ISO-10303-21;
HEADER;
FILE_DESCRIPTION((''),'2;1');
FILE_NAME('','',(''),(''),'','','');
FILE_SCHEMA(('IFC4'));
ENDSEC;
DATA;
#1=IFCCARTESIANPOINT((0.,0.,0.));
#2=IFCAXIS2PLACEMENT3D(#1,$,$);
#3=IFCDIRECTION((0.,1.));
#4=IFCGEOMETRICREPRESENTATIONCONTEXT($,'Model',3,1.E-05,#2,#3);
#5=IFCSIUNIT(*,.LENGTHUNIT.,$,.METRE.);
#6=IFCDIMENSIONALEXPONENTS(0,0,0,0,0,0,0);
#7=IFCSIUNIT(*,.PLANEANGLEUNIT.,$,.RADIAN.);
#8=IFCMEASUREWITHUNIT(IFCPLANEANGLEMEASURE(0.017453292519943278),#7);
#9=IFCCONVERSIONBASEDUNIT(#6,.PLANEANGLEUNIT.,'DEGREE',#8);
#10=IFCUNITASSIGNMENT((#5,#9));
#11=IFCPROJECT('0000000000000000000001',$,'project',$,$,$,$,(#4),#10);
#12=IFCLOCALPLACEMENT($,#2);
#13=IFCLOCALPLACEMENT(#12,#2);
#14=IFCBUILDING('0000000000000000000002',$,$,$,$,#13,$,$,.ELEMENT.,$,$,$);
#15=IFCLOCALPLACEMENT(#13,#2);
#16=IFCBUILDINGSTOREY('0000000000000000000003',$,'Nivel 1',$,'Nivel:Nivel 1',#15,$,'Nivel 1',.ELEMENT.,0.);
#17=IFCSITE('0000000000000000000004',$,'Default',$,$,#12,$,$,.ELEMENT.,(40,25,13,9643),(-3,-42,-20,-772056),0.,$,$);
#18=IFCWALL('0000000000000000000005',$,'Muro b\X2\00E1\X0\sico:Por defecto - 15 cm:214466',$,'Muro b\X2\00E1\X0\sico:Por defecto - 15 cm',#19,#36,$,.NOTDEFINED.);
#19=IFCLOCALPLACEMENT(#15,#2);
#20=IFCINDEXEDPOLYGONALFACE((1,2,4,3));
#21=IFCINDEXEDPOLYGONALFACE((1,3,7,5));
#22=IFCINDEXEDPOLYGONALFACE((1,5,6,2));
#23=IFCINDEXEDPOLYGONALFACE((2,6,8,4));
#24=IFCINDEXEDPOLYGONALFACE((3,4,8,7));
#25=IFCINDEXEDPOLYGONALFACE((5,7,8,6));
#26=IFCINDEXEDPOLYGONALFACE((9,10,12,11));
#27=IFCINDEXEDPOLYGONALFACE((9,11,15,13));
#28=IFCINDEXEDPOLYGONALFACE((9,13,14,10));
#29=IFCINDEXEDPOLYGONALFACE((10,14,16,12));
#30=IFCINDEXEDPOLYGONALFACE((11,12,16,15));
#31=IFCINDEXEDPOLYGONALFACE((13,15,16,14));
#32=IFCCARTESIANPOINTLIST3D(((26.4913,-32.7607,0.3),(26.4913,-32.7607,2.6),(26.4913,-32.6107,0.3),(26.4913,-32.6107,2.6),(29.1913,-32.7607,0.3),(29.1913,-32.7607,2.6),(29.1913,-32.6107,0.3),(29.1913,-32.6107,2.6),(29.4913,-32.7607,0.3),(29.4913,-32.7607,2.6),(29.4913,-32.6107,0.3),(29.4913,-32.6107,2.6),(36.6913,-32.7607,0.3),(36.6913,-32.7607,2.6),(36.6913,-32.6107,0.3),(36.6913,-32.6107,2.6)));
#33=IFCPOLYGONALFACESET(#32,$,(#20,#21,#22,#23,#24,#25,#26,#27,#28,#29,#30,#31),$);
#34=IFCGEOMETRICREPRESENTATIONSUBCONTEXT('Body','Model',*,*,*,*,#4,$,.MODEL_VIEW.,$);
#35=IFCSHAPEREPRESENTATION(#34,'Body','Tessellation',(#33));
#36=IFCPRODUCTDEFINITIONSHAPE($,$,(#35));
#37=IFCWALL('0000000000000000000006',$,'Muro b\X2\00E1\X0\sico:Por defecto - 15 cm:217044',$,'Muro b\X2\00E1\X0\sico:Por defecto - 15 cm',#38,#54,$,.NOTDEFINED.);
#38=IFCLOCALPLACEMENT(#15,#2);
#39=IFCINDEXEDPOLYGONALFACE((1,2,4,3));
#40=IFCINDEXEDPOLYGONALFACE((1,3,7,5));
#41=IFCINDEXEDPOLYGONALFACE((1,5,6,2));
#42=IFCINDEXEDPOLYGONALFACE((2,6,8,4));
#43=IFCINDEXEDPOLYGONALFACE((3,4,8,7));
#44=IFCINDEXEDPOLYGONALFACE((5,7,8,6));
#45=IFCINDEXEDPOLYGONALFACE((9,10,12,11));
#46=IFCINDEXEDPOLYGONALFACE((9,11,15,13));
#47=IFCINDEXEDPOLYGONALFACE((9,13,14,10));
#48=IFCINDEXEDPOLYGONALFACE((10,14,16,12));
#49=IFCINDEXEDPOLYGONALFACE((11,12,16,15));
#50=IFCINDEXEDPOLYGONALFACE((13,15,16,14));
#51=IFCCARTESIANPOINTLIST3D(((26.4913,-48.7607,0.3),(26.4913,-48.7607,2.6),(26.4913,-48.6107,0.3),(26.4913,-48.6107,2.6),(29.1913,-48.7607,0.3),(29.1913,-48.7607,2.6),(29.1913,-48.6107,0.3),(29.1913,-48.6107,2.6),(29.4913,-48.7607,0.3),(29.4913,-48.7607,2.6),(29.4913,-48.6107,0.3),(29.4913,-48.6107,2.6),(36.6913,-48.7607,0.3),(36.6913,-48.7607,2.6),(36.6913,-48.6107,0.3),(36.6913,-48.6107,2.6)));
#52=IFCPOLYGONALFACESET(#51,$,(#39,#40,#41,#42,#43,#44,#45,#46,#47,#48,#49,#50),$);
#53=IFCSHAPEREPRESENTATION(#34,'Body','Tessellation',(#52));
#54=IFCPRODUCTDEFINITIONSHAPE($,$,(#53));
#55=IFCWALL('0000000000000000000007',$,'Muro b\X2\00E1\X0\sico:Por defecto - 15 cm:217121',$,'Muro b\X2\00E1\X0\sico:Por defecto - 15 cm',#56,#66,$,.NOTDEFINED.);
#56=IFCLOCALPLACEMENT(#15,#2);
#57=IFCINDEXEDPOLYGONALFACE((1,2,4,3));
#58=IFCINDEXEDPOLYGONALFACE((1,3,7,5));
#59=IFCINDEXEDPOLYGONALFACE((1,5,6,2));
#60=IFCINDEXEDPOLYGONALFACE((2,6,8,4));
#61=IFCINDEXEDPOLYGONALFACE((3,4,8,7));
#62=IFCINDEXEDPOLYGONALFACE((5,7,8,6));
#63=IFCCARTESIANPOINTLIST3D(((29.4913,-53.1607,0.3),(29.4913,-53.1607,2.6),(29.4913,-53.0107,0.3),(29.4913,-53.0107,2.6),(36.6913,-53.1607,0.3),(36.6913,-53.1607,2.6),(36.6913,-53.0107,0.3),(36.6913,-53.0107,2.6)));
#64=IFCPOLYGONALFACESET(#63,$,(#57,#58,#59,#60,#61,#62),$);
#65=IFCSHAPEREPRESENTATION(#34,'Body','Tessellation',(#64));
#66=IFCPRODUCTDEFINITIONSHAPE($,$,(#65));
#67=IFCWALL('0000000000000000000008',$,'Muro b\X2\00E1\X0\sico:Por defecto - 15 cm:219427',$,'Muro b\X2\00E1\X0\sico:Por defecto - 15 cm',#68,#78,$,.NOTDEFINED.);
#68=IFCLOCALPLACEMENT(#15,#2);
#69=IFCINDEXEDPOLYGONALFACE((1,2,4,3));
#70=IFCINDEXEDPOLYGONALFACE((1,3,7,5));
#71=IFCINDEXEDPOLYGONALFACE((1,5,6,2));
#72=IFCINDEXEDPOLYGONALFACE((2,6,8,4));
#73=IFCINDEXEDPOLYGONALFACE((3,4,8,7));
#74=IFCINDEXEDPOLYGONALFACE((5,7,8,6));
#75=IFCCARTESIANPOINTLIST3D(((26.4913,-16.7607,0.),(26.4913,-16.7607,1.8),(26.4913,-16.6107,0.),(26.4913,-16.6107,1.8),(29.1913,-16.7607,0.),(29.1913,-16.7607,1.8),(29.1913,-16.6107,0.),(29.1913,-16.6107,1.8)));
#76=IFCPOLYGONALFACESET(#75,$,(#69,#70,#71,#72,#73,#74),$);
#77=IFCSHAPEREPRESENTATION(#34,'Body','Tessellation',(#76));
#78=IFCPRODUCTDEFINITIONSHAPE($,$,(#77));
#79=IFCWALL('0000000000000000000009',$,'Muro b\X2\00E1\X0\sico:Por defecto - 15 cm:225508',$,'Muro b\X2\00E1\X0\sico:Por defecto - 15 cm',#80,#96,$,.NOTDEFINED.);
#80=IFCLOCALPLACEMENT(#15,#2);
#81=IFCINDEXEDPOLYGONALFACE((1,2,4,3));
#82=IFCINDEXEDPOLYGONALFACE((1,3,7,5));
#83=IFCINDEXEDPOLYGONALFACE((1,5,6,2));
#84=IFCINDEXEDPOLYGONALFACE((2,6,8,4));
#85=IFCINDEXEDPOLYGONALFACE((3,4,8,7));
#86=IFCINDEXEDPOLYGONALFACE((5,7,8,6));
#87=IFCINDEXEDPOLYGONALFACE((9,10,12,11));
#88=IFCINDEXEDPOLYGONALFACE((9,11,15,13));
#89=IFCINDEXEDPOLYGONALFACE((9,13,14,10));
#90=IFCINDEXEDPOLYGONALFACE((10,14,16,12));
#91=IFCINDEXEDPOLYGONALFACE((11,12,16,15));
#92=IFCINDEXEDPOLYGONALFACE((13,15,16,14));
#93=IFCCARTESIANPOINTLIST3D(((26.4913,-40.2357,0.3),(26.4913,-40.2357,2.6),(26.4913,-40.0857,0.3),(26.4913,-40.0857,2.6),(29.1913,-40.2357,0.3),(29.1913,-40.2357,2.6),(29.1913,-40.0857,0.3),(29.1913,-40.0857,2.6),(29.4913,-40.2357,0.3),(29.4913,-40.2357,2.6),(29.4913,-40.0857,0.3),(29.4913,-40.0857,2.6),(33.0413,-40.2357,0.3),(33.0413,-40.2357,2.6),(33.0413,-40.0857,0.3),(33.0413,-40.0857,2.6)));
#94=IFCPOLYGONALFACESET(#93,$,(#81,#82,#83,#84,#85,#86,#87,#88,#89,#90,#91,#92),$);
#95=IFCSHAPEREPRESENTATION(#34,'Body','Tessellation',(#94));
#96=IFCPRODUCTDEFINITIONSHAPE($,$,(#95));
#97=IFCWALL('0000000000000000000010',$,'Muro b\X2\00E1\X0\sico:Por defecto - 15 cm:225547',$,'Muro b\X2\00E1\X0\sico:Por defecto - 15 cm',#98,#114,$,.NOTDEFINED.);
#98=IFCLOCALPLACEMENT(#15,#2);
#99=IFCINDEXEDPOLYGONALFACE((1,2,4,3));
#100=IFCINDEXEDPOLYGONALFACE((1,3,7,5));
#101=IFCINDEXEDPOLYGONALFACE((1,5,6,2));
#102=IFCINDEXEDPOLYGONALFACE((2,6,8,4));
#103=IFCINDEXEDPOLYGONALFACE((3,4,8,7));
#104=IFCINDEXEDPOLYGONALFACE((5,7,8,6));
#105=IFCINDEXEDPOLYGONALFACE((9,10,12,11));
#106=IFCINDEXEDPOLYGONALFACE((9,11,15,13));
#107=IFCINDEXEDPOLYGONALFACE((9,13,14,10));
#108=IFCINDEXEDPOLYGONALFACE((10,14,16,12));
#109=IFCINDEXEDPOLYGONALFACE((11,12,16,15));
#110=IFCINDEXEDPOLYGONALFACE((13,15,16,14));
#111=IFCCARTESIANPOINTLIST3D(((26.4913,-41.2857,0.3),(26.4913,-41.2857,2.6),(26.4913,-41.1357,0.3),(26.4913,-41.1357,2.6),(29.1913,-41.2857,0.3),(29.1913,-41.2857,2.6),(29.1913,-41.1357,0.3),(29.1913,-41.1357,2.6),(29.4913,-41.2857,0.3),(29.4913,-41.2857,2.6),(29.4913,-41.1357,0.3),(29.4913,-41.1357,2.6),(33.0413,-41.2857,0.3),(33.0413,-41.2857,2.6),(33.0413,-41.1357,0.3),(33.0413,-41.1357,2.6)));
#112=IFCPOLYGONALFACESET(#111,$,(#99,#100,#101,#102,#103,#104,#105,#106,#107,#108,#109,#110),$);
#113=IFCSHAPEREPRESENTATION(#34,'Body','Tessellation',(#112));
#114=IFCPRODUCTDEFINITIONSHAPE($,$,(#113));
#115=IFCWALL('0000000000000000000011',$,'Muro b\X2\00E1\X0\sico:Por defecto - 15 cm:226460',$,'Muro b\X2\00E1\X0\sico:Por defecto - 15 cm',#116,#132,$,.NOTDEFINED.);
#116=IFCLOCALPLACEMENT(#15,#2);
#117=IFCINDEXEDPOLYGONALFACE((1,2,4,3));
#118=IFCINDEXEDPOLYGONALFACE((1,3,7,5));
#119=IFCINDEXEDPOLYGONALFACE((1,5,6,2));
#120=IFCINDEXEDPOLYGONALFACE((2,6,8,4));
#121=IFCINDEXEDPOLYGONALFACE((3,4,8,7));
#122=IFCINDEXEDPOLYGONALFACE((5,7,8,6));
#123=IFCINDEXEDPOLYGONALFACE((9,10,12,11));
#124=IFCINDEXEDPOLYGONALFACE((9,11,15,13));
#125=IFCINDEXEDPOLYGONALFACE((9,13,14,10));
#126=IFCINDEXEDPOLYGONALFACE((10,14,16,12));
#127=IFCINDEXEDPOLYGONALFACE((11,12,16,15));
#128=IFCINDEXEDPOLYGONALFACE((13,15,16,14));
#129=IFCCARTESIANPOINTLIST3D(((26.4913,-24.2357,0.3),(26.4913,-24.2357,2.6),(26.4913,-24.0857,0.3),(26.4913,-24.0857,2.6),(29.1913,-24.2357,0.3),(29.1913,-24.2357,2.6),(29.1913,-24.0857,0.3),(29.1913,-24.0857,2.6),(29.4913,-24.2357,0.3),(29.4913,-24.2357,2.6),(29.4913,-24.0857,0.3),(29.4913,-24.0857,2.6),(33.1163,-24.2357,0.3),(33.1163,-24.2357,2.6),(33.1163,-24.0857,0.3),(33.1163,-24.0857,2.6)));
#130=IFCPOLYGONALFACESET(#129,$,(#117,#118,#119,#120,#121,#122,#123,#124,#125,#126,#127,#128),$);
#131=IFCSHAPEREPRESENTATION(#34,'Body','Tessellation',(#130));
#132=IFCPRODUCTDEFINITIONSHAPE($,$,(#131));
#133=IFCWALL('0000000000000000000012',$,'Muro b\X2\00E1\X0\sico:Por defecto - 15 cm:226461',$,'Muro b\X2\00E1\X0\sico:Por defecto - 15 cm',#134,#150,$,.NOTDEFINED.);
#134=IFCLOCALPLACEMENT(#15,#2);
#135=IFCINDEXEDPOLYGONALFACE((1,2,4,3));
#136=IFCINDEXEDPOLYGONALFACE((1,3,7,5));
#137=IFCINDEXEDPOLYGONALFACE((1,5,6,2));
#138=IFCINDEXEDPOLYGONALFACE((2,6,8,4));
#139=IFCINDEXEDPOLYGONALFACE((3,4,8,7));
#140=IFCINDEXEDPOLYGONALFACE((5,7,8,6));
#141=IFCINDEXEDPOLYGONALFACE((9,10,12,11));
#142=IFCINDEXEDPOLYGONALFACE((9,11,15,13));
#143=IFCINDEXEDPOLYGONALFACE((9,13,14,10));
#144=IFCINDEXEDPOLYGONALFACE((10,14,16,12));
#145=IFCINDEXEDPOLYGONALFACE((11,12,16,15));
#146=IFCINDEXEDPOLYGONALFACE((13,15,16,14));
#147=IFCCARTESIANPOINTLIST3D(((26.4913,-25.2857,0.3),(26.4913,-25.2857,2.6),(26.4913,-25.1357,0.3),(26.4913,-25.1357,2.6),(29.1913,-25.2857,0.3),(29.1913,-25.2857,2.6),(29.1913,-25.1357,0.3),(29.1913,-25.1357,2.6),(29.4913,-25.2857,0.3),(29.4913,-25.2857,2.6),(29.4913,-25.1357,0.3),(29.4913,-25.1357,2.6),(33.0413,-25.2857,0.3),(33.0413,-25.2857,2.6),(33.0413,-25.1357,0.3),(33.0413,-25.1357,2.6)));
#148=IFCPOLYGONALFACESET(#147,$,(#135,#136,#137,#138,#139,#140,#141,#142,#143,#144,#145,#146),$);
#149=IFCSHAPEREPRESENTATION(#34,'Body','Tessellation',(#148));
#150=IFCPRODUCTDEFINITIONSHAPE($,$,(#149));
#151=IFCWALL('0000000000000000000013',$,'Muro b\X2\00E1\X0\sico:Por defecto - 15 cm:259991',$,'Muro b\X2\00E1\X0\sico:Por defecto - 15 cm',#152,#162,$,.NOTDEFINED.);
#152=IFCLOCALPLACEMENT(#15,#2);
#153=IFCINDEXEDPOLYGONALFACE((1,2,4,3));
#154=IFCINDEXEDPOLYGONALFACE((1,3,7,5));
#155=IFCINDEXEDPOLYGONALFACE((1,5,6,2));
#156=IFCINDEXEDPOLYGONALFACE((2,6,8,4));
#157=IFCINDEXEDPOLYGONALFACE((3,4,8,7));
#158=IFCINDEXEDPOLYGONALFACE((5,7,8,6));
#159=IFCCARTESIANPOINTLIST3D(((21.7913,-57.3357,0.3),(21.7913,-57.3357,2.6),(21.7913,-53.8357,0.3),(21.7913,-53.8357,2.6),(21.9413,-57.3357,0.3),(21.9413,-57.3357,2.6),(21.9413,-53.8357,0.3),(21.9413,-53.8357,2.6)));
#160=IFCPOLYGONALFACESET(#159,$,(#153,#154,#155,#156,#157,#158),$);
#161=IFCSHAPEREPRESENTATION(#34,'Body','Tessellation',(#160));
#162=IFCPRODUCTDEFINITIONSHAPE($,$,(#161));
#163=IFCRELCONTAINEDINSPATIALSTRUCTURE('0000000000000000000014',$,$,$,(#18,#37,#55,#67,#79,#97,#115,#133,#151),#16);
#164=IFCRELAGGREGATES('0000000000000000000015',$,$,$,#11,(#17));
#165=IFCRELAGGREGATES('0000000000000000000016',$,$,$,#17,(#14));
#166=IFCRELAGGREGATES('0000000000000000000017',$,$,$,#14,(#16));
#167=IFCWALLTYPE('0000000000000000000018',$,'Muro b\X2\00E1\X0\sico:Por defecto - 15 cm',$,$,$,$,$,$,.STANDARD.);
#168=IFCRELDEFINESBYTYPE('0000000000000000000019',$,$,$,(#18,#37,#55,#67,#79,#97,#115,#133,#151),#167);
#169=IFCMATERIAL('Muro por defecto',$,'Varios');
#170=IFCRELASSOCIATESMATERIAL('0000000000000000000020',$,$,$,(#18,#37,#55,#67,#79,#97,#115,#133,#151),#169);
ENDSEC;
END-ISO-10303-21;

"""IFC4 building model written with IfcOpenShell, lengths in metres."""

from ifc_helpers import new_model, entity, si_unit, converted_unit, direction, frame, origin, place, context, subcontext, project, spatial, indexed_curve, outline, extrude, material, type_object, element, save


model = new_model("IFC4")

# Units and contexts
model_context = context("Model", 3, precision=1e-05, world=origin(), true_north=direction((0.0, 1.0)))
body_context = subcontext(model_context, "Body", "Model", "MODEL_VIEW")
ifc_project = project(units=[si_unit("LENGTHUNIT", "METRE"), converted_unit("PLANEANGLEUNIT", "DEGREE", entity("IfcPlaneAngleMeasure", 0.017453292519943278), si_unit("PLANEANGLEUNIT", "RADIAN"), dimensions=[0, 0, 0, 0, 0, 0, 0])], contexts=[model_context])

# Site, building, storey
site_placement = place(None, origin())
site = spatial("IfcSite", under=ifc_project, at=site_placement, Name="Default", CompositionType="ELEMENT", RefLatitude=(40, 25, 13, 9643), RefLongitude=(-3, -42, -20, -772056), RefElevation=0.0)
building_placement = place(site_placement, origin())
building = spatial("IfcBuilding", under=site, at=building_placement, CompositionType="ELEMENT")
storey_placement = place(building_placement, origin())
storey = spatial("IfcBuildingStorey", under=building, at=storey_placement, Name="Nivel 1", ObjectType="Nivel:Nivel 1", LongName="Nivel 1", CompositionType="ELEMENT", Elevation=0.0)

# Shared definitions
ifc_material = material(Name="Muro por defecto", Category="Varios")
wall_type_1 = type_object("IfcWallType", Name="Muro básico:Por defecto - 15 cm", PredefinedType="STANDARD")

# Walls, openings
wall_1_placement = place(storey_placement, frame((36.6913, -32.6857, 0.3), z_axis=(0.0, 0.0, 1.0), x_axis=(-1.0, 0.0, 0.0)))
wall_1 = element("IfcWall", 1, at=wall_1_placement, inside=storey, type_object=wall_type_1, material=ifc_material, Name="Muro básico:Por defecto - 15 cm:214466", ObjectType="Muro básico:Por defecto - 15 cm", PredefinedType="NOTDEFINED", context=body_context, shape_type="SweptSolid", body=[
    extrude(outline(indexed_curve([(10.2, 0.075), (0.0, 0.075), (0.0, -0.075), (10.2, -0.075), (10.2, 0.075)], self_intersect=False)), origin(), (0.0, 0.0, 1.0), 2.3),
])
opening_1_placement = place(storey_placement, frame((36.6913, -32.6857, 0.3), z_axis=(0.0, 0.0, 1.0), x_axis=(-1.0, 0.0, 0.0)))
element("IfcOpeningElement", 2, at=opening_1_placement, cuts=wall_1, PredefinedType="OPENING", context=body_context, shape_type="SweptSolid", body=[
    extrude(outline(indexed_curve([(-1.15, -0.075), (1.15, -0.075), (1.15, 0.075), (-1.15, 0.075), (-1.15, -0.075)], self_intersect=False)), frame((7.5, 0.0, 1.15), z_axis=(-1.0, 0.0, 0.0), x_axis=(0.0, 0.0, 1.0)), (0.0, 0.0, 1.0), 0.3),
])
wall_2_placement = place(storey_placement, frame((36.6913, -48.6857, 0.3), z_axis=(0.0, 0.0, 1.0), x_axis=(-1.0, 0.0, 0.0)))
wall_2 = element("IfcWall", 3, at=wall_2_placement, inside=storey, type_object=wall_type_1, material=ifc_material, Name="Muro básico:Por defecto - 15 cm:217044", ObjectType="Muro básico:Por defecto - 15 cm", PredefinedType="NOTDEFINED", context=body_context, shape_type="SweptSolid", body=[
    extrude(outline(indexed_curve([(10.2, 0.075), (0.0, 0.075), (0.0, -0.075), (10.2, -0.075), (10.2, 0.075)], self_intersect=False)), origin(), (0.0, 0.0, 1.0), 2.3),
])
opening_2_placement = place(storey_placement, frame((36.6913, -48.6857, 0.3), z_axis=(0.0, 0.0, 1.0), x_axis=(-1.0, 0.0, 0.0)))
element("IfcOpeningElement", 4, at=opening_2_placement, cuts=wall_2, PredefinedType="OPENING", context=body_context, shape_type="SweptSolid", body=[
    extrude(outline(indexed_curve([(-1.15, -0.075), (1.15, -0.075), (1.15, 0.075), (-1.15, 0.075), (-1.15, -0.075)], self_intersect=False)), frame((7.5, 0.0, 1.15), z_axis=(-1.0, 0.0, 0.0), x_axis=(0.0, 0.0, 1.0)), (0.0, 0.0, 1.0), 0.3),
])

# Walls
wall_3_placement = place(storey_placement, frame((36.6913, -53.0857, 0.3), z_axis=(0.0, 0.0, 1.0), x_axis=(-1.0, 0.0, 0.0)))
element("IfcWall", 5, at=wall_3_placement, inside=storey, type_object=wall_type_1, material=ifc_material, Name="Muro básico:Por defecto - 15 cm:217121", ObjectType="Muro básico:Por defecto - 15 cm", PredefinedType="NOTDEFINED", context=body_context, shape_type="SweptSolid", body=[
    extrude(outline(indexed_curve([(7.2, 0.075), (0.0, 0.075), (0.0, -0.075), (7.2, -0.075), (7.2, 0.075)], self_intersect=False)), origin(), (0.0, 0.0, 1.0), 2.3),
])
wall_4_placement = place(storey_placement, frame((26.4913, -16.6857, 0.0)))
element("IfcWall", 6, at=wall_4_placement, inside=storey, type_object=wall_type_1, material=ifc_material, Name="Muro básico:Por defecto - 15 cm:219427", ObjectType="Muro básico:Por defecto - 15 cm", PredefinedType="NOTDEFINED", context=body_context, shape_type="SweptSolid", body=[
    extrude(outline(indexed_curve([(2.7, 0.075), (0.0, 0.075), (0.0, -0.075), (2.7, -0.075), (2.7, 0.075)], self_intersect=False)), origin(), (0.0, 0.0, 1.0), 1.8),
])

# Walls, openings
wall_5_placement = place(storey_placement, frame((26.4913, -40.1607, 0.3)))
wall_5 = element("IfcWall", 7, at=wall_5_placement, inside=storey, type_object=wall_type_1, material=ifc_material, Name="Muro básico:Por defecto - 15 cm:225508", ObjectType="Muro básico:Por defecto - 15 cm", PredefinedType="NOTDEFINED", context=body_context, shape_type="SweptSolid", body=[
    extrude(outline(indexed_curve([(6.55, 0.075), (0.0, 0.075), (0.0, -0.075), (6.55, -0.075), (6.55, 0.075)], self_intersect=False)), origin(), (0.0, 0.0, 1.0), 2.3),
])
opening_3_placement = place(storey_placement, frame((26.4913, -40.1607, 0.3)))
element("IfcOpeningElement", 8, at=opening_3_placement, cuts=wall_5, PredefinedType="OPENING", context=body_context, shape_type="SweptSolid", body=[
    extrude(outline(indexed_curve([(-1.15, -0.075), (1.15, -0.075), (1.15, 0.075), (-1.15, 0.075), (-1.15, -0.075)], self_intersect=False)), frame((2.7, 0.0, 1.15), z_axis=(1.0, 0.0, 0.0), x_axis=(0.0, 0.0, -1.0)), (0.0, 0.0, 1.0), 0.3),
])
wall_6_placement = place(storey_placement, frame((33.0413, -41.2107, 0.3), z_axis=(0.0, 0.0, 1.0), x_axis=(-1.0, 0.0, 0.0)))
wall_6 = element("IfcWall", 9, at=wall_6_placement, inside=storey, type_object=wall_type_1, material=ifc_material, Name="Muro básico:Por defecto - 15 cm:225547", ObjectType="Muro básico:Por defecto - 15 cm", PredefinedType="NOTDEFINED", context=body_context, shape_type="SweptSolid", body=[
    extrude(outline(indexed_curve([(6.55, 0.075), (0.0, 0.075), (0.0, -0.075), (6.55, -0.075), (6.55, 0.075)], self_intersect=False)), origin(), (0.0, 0.0, 1.0), 2.3),
])
opening_4_placement = place(storey_placement, frame((33.0413, -41.2107, 0.3), z_axis=(0.0, 0.0, 1.0), x_axis=(-1.0, 0.0, 0.0)))
element("IfcOpeningElement", 10, at=opening_4_placement, cuts=wall_6, PredefinedType="OPENING", context=body_context, shape_type="SweptSolid", body=[
    extrude(outline(indexed_curve([(-1.15, -0.075), (1.15, -0.075), (1.15, 0.075), (-1.15, 0.075), (-1.15, -0.075)], self_intersect=False)), frame((3.85, 0.0, 1.15), z_axis=(-1.0, 0.0, 0.0), x_axis=(0.0, 0.0, 1.0)), (0.0, 0.0, 1.0), 0.3),
])
wall_7_placement = place(storey_placement, frame((26.4913, -24.1607, 0.3)))
wall_7 = element("IfcWall", 11, at=wall_7_placement, inside=storey, type_object=wall_type_1, material=ifc_material, Name="Muro básico:Por defecto - 15 cm:226460", ObjectType="Muro básico:Por defecto - 15 cm", PredefinedType="NOTDEFINED", context=body_context, shape_type="SweptSolid", body=[
    extrude(outline(indexed_curve([(6.625, 0.075), (0.0, 0.075), (0.0, -0.075), (6.625, -0.075), (6.625, 0.075)], self_intersect=False)), origin(), (0.0, 0.0, 1.0), 2.3),
])
opening_5_placement = place(storey_placement, frame((26.4913, -24.1607, 0.3)))
element("IfcOpeningElement", 12, at=opening_5_placement, cuts=wall_7, PredefinedType="OPENING", context=body_context, shape_type="SweptSolid", body=[
    extrude(outline(indexed_curve([(-1.15, -0.075), (1.15, -0.075), (1.15, 0.075), (-1.15, 0.075), (-1.15, -0.075)], self_intersect=False)), frame((2.7, 0.0, 1.15), z_axis=(1.0, 0.0, 0.0), x_axis=(0.0, 0.0, -1.0)), (0.0, 0.0, 1.0), 0.3),
])
wall_8_placement = place(storey_placement, frame((33.0413, -25.2107, 0.3), z_axis=(0.0, 0.0, 1.0), x_axis=(-1.0, 0.0, 0.0)))
wall_8 = element("IfcWall", 13, at=wall_8_placement, inside=storey, type_object=wall_type_1, material=ifc_material, Name="Muro básico:Por defecto - 15 cm:226461", ObjectType="Muro básico:Por defecto - 15 cm", PredefinedType="NOTDEFINED", context=body_context, shape_type="SweptSolid", body=[
    extrude(outline(indexed_curve([(6.55, 0.075), (0.0, 0.075), (0.0, -0.075), (6.55, -0.075), (6.55, 0.075)], self_intersect=False)), origin(), (0.0, 0.0, 1.0), 2.3),
])
opening_6_placement = place(storey_placement, frame((33.0413, -25.2107, 0.3), z_axis=(0.0, 0.0, 1.0), x_axis=(-1.0, 0.0, 0.0)))
element("IfcOpeningElement", 14, at=opening_6_placement, cuts=wall_8, PredefinedType="OPENING", context=body_context, shape_type="SweptSolid", body=[
    extrude(outline(indexed_curve([(-1.15, -0.075), (1.15, -0.075), (1.15, 0.075), (-1.15, 0.075), (-1.15, -0.075)], self_intersect=False)), frame((3.85, 0.0, 1.15), z_axis=(-1.0, 0.0, 0.0), x_axis=(0.0, 0.0, 1.0)), (0.0, 0.0, 1.0), 0.3),
])

# Wall
wall_9_placement = place(storey_placement, frame((21.8663, -53.8357, 0.3), z_axis=(0.0, 0.0, 1.0), x_axis=(0.0, -1.0, 0.0)))
element("IfcWall", 15, at=wall_9_placement, inside=storey, type_object=wall_type_1, material=ifc_material, Name="Muro básico:Por defecto - 15 cm:259991", ObjectType="Muro básico:Por defecto - 15 cm", PredefinedType="NOTDEFINED", context=body_context, shape_type="SweptSolid", body=[
    extrude(outline(indexed_curve([(3.5, 0.075), (0.0, 0.075), (0.0, -0.075), (3.5, -0.075), (3.5, 0.075)], self_intersect=False)), origin(), (0.0, 0.0, 1.0), 2.3),
])

save(model, "model.ifc")
